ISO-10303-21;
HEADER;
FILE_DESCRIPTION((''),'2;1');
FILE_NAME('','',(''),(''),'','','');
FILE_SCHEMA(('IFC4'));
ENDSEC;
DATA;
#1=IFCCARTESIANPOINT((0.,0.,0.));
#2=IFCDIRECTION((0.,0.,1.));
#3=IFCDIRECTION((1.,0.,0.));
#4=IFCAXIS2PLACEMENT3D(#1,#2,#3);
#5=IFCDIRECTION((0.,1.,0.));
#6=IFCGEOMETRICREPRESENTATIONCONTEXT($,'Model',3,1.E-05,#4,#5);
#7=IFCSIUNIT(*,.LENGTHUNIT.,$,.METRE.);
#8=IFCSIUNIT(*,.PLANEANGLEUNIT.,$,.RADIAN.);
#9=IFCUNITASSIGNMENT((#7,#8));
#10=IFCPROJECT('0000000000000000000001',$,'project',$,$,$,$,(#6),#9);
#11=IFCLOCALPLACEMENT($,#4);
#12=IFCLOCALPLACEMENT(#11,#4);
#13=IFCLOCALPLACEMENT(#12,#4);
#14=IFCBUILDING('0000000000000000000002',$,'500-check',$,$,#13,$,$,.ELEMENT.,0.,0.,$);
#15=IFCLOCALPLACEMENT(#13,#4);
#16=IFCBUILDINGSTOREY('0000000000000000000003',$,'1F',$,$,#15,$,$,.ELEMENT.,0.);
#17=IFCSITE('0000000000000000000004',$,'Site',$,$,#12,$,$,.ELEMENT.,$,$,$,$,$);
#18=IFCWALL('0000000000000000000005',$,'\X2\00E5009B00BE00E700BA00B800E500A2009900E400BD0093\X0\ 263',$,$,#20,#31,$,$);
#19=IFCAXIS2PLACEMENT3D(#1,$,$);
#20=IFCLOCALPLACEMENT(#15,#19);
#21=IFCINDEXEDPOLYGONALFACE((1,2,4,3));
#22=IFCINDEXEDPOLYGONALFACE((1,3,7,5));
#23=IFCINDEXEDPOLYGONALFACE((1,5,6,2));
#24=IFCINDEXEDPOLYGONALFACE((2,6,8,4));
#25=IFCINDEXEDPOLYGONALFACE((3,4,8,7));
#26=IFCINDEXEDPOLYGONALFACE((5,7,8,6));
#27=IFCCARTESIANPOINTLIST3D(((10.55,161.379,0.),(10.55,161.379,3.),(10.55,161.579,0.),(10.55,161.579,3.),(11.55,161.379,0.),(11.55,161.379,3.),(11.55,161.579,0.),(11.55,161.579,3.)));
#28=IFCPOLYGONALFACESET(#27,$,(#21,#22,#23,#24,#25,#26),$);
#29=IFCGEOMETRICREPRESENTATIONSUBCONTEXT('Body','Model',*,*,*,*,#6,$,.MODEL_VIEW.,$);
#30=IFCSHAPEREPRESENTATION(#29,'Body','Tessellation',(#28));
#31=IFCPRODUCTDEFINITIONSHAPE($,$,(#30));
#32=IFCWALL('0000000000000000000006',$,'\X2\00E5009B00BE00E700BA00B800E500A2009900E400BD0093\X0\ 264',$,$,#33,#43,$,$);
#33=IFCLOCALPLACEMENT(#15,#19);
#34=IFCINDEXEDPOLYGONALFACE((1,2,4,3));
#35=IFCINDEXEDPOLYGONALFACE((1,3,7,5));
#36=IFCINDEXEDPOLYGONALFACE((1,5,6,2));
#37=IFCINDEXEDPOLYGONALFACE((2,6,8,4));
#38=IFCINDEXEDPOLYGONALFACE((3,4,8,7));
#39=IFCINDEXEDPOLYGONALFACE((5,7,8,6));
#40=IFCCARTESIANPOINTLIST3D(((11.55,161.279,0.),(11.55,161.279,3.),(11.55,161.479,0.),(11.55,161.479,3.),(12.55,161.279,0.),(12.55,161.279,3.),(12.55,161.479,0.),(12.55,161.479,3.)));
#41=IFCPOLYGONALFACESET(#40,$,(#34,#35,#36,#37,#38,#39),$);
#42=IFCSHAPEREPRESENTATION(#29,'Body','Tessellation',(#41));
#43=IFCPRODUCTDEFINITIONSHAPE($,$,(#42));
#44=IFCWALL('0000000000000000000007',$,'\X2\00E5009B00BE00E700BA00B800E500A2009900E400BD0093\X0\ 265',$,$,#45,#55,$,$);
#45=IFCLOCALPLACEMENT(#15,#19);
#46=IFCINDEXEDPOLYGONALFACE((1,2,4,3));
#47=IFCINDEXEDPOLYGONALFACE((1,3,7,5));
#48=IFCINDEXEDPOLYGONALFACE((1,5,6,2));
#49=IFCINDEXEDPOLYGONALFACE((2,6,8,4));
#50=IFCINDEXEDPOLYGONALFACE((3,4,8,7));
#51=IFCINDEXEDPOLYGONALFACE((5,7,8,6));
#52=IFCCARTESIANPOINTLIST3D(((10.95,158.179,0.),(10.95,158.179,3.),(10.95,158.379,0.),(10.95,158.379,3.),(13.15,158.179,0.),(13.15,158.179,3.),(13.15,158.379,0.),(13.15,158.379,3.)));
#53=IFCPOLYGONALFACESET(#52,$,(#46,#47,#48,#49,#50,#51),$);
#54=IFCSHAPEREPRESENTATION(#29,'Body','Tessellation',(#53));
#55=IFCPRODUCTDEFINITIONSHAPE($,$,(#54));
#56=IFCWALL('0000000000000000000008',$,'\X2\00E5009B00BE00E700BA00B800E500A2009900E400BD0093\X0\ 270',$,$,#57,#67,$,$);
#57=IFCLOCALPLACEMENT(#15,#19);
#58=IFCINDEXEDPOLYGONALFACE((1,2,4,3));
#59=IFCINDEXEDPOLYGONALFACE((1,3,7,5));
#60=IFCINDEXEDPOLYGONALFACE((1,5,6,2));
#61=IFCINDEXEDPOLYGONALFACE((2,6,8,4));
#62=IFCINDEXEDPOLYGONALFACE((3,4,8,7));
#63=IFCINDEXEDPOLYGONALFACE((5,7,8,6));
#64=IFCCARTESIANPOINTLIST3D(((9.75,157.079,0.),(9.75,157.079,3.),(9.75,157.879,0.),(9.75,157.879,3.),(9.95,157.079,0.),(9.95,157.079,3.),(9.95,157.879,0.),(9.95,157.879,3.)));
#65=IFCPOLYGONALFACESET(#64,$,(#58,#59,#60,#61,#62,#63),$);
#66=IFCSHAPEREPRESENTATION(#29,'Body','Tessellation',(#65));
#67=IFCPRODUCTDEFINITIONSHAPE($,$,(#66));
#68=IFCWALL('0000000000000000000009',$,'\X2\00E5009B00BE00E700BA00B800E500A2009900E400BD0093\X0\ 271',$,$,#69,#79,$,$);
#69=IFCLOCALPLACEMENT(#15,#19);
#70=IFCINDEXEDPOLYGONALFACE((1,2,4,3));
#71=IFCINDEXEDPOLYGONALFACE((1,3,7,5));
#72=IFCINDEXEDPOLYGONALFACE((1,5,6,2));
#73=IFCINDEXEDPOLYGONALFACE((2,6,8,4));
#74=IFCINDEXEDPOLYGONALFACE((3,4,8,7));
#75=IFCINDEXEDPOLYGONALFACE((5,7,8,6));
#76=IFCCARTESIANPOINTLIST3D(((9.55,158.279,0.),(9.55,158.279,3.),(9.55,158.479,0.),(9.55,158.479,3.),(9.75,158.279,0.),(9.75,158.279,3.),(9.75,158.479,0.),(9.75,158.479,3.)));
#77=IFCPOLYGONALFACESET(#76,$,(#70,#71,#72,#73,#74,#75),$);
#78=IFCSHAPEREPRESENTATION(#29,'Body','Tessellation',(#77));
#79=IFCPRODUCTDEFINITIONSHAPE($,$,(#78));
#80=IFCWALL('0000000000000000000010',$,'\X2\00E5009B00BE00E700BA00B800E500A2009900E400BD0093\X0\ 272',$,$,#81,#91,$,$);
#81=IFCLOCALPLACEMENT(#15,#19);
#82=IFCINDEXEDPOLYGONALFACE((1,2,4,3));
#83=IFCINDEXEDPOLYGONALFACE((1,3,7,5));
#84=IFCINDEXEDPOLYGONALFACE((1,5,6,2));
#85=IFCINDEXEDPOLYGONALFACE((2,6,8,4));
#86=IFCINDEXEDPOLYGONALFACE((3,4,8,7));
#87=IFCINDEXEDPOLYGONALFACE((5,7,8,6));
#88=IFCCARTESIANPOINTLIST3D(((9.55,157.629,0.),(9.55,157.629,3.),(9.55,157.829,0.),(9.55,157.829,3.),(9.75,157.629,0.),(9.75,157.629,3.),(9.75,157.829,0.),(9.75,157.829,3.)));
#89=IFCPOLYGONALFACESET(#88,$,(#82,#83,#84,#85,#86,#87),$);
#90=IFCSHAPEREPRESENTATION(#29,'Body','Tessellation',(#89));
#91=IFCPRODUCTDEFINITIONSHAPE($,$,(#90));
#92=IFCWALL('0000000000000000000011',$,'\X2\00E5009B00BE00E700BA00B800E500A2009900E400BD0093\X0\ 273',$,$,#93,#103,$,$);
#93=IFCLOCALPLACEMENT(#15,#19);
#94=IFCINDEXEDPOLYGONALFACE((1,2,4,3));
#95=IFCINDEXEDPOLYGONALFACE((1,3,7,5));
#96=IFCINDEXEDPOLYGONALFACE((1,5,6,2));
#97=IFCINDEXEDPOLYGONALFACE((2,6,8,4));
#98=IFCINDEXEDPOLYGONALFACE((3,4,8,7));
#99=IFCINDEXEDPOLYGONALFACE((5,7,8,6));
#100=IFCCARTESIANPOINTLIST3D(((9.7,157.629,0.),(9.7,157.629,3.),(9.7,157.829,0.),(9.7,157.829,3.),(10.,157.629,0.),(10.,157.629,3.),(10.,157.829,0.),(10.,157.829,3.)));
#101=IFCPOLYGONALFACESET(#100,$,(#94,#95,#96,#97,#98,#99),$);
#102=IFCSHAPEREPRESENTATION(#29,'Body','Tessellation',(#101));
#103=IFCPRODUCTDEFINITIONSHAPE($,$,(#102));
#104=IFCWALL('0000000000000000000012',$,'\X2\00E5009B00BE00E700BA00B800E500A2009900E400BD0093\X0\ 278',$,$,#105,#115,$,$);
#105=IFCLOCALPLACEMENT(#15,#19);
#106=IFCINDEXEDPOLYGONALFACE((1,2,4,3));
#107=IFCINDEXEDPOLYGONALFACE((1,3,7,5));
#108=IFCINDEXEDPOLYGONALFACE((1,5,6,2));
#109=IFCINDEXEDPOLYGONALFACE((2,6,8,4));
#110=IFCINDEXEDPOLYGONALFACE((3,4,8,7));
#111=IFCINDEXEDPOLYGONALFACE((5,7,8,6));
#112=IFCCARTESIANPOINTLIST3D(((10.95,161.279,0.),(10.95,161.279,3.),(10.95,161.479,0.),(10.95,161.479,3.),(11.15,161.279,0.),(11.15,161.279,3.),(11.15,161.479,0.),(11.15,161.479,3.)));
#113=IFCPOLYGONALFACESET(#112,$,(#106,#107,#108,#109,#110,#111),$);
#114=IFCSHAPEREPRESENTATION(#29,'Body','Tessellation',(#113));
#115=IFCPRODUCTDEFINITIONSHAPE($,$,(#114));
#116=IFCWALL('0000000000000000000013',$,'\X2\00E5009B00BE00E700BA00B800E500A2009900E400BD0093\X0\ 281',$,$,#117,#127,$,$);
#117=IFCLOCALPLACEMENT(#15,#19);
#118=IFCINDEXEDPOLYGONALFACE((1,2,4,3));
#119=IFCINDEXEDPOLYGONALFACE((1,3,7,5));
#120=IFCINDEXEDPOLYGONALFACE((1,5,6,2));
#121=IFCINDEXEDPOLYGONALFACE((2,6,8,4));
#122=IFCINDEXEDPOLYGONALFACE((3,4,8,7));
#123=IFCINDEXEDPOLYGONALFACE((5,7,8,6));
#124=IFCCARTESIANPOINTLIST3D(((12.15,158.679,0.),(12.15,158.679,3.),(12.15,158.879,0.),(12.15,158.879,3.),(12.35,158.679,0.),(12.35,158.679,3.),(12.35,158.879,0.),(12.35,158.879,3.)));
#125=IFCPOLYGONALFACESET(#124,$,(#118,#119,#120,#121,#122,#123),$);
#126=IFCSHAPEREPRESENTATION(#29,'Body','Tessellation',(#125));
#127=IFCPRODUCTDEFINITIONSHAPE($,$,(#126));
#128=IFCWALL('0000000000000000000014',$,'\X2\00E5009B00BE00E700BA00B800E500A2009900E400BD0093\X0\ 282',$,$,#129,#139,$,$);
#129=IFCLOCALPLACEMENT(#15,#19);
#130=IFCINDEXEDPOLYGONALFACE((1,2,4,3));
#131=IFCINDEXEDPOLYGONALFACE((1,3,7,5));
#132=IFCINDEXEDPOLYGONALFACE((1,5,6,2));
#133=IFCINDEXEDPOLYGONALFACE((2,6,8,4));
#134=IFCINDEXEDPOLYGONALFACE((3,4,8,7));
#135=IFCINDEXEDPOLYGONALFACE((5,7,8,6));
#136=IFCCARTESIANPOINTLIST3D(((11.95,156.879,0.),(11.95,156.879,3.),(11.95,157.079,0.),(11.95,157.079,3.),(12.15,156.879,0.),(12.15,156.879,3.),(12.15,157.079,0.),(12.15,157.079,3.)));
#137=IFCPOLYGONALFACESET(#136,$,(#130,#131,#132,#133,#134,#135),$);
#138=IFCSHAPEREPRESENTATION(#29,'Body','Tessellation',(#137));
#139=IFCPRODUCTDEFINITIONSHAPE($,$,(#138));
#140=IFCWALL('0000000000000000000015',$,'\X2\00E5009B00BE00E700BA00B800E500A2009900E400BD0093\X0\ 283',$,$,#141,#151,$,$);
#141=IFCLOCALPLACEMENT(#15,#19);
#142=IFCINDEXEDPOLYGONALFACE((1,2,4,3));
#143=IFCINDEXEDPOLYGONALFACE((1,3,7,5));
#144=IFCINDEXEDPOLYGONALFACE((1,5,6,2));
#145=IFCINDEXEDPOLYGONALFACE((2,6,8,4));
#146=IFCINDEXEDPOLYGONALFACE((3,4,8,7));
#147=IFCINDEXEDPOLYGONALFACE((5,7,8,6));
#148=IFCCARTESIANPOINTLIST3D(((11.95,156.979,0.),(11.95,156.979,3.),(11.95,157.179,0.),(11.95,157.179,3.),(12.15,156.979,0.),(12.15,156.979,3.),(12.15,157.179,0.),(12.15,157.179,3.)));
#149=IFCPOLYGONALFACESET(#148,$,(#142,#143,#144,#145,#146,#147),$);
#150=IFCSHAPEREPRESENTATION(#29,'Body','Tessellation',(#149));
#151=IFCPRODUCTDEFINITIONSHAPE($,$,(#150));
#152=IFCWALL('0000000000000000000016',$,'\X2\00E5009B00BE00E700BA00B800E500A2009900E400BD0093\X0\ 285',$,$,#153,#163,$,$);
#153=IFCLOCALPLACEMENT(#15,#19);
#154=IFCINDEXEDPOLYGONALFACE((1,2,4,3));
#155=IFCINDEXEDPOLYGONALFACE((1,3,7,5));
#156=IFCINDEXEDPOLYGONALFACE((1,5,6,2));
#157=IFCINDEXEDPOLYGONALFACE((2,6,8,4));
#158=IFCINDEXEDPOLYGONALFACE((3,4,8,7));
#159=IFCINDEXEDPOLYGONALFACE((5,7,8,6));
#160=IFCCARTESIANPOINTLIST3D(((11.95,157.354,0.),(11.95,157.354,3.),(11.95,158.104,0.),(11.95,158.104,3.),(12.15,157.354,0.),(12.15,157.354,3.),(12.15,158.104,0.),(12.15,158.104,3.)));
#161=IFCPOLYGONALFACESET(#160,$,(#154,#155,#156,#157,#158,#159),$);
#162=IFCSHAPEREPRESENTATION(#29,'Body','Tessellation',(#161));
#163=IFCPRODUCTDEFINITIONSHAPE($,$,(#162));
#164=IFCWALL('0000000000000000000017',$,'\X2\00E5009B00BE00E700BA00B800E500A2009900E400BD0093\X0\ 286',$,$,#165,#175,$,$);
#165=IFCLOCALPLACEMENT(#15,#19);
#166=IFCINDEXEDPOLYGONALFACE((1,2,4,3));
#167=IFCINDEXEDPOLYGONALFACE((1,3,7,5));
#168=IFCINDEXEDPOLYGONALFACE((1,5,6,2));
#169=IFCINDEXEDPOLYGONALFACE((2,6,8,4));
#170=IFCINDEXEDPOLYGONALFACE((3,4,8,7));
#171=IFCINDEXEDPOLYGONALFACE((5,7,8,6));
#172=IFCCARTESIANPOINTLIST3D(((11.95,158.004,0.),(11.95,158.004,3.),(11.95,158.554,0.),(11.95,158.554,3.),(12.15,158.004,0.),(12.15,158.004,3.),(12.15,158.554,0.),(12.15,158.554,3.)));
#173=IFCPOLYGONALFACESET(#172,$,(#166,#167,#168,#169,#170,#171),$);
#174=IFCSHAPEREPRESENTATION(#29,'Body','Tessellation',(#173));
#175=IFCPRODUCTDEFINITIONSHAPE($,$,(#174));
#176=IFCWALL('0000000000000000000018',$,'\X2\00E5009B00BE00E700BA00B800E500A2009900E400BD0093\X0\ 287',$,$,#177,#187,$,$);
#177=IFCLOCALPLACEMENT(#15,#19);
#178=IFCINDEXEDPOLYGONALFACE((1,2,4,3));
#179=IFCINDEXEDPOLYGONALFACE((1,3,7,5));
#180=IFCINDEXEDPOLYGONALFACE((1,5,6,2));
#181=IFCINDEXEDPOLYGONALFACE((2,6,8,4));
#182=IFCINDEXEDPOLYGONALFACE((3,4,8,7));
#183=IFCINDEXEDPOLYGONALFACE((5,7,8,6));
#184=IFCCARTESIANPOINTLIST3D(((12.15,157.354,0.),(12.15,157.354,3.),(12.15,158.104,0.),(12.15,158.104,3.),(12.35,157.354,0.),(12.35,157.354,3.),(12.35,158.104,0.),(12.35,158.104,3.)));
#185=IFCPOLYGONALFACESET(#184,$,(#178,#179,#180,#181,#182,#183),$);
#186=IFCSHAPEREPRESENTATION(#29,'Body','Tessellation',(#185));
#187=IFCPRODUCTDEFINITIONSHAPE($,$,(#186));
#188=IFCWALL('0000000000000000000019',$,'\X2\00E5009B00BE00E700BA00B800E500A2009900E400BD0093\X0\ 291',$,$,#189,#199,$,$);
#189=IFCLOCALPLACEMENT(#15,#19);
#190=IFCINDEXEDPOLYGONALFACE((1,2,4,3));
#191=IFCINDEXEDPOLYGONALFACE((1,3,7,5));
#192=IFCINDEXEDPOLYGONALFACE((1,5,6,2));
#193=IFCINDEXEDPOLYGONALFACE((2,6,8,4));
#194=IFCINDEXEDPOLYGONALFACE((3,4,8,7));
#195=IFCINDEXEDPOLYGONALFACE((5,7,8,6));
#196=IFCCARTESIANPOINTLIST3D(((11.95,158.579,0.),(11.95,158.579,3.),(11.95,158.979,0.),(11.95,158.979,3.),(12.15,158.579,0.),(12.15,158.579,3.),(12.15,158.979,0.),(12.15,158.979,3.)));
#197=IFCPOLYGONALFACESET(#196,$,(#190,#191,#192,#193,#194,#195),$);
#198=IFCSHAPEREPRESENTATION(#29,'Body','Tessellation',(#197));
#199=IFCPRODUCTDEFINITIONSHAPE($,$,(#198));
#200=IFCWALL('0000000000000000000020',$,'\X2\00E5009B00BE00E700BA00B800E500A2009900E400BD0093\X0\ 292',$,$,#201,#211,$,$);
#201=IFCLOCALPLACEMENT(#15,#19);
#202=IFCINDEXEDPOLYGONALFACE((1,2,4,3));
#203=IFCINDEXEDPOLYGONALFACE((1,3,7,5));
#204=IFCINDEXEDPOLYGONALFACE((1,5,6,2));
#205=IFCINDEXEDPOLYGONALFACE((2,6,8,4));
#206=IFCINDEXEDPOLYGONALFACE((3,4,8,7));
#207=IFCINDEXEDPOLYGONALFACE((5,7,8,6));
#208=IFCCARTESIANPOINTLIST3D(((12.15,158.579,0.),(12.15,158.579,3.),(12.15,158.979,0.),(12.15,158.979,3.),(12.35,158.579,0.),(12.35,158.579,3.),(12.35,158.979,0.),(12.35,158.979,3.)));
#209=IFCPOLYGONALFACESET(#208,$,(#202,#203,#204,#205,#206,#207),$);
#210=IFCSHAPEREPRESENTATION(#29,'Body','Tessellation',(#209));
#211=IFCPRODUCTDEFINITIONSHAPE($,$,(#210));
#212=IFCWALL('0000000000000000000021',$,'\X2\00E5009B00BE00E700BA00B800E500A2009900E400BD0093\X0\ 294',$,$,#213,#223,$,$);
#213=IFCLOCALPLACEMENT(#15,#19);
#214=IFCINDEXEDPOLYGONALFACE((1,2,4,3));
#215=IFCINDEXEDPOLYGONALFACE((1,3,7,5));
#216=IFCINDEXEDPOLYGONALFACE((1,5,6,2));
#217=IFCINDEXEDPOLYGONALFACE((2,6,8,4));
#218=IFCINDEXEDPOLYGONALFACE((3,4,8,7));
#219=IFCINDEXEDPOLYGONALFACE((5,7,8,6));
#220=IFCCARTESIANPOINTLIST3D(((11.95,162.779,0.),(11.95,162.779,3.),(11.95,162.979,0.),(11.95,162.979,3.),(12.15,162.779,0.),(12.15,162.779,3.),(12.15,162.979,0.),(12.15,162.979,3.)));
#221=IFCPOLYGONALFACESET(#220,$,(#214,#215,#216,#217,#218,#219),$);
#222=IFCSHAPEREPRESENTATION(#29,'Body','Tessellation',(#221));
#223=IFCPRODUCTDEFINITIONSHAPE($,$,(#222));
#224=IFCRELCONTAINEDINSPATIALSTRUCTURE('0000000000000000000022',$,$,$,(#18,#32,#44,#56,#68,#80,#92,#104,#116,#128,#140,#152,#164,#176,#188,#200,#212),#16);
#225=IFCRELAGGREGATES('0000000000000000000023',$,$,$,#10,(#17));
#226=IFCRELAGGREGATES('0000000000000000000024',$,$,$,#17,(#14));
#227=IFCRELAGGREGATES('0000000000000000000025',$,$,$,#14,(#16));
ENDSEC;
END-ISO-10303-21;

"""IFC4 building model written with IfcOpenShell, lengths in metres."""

from ifc_helpers import new_model, si_unit, direction, frame, frame_2d, origin_with_axes, place, context, subcontext, project, spatial, rectangle, extrude, element, save


model = new_model("IFC4")

# Units and contexts
model_context = context("Model", 3, precision=1e-05, world=origin_with_axes(), true_north=direction((0.0, 1.0, 0.0)))
body_context = subcontext(model_context, "Body", "Model", "MODEL_VIEW")
ifc_project = project(units=[si_unit("LENGTHUNIT", "METRE"), si_unit("PLANEANGLEUNIT", "RADIAN")], contexts=[model_context])

# Site, building, storey
placement = place(None, origin_with_axes())
site_placement = place(placement, origin_with_axes())
site = spatial("IfcSite", under=ifc_project, at=site_placement, Name="Site", CompositionType="ELEMENT")
building_placement = place(site_placement, origin_with_axes())
building = spatial("IfcBuilding", under=site, at=building_placement, Name="500-check", CompositionType="ELEMENT", ElevationOfRefHeight=0.0, ElevationOfTerrain=0.0)
storey_placement = place(building_placement, origin_with_axes())
storey = spatial("IfcBuildingStorey", under=building, at=storey_placement, Name="1F", CompositionType="ELEMENT", Elevation=0.0)

# Walls
for number, where, z_axis, x_axis, name in (
    (1, (11.05, 161.479, 0.0), (0.0, 0.0, 1.0), (1.0, 0.0, 0.0), "å\u009b¾çº¸å¢\u0099ä½\u0093 263"),
    (2, (12.05, 161.379, 0.0), (0.0, 0.0, 1.0), (-1.0, 0.0, 0.0), "å\u009b¾çº¸å¢\u0099ä½\u0093 264"),
):
    element("IfcWall", number, at=place(storey_placement, frame(where, z_axis=z_axis, x_axis=x_axis)), inside=storey, Name=name, context=body_context, shape_type="SweptSolid", body=[
        extrude(rectangle(XDim=1.0, YDim=0.2, at=frame_2d((0.0, 0.0), x_axis=(1.0, 0.0, 0.0))), frame((0.0, 0.0, 0.0), z_axis=(0.0, 0.0, 1.0)), (0.0, 0.0, 1.0), 3.0),
    ])
wall_1_placement = place(storey_placement, frame((12.05, 158.279, 0.0), z_axis=(0.0, 0.0, 1.0), x_axis=(-1.0, 0.0, 0.0)))
element("IfcWall", 3, at=wall_1_placement, inside=storey, Name="å\u009b¾çº¸å¢\u0099ä½\u0093 265", context=body_context, shape_type="SweptSolid", body=[
    extrude(rectangle(XDim=2.2, YDim=0.2, at=frame_2d((0.0, 0.0), x_axis=(1.0, 0.0, 0.0))), frame((0.0, 0.0, 0.0), z_axis=(0.0, 0.0, 1.0)), (0.0, 0.0, 1.0), 3.0),
])
wall_2_placement = place(storey_placement, frame((9.85, 157.479, 0.0), z_axis=(0.0, 0.0, 1.0), x_axis=(0.0, 1.0, 0.0)))
element("IfcWall", 4, at=wall_2_placement, inside=storey, Name="å\u009b¾çº¸å¢\u0099ä½\u0093 270", context=body_context, shape_type="SweptSolid", body=[
    extrude(rectangle(XDim=0.8, YDim=0.2, at=frame_2d((0.0, 0.0), x_axis=(1.0, 0.0, 0.0))), frame((0.0, 0.0, 0.0), z_axis=(0.0, 0.0, 1.0)), (0.0, 0.0, 1.0), 3.0),
])
for number, where, z_axis, x_axis, name in (
    (5, (9.65, 158.379, 0.0), (0.0, 0.0, 1.0), (1.0, 0.0, 0.0), "å\u009b¾çº¸å¢\u0099ä½\u0093 271"),
    (6, (9.65, 157.729, 0.0), (0.0, 0.0, 1.0), (1.0, 0.0, 0.0), "å\u009b¾çº¸å¢\u0099ä½\u0093 272"),
):
    element("IfcWall", number, at=place(storey_placement, frame(where, z_axis=z_axis, x_axis=x_axis)), inside=storey, Name=name, context=body_context, shape_type="SweptSolid", body=[
        extrude(rectangle(XDim=0.2, YDim=0.2, at=frame_2d((0.0, 0.0), x_axis=(1.0, 0.0, 0.0))), frame((0.0, 0.0, 0.0), z_axis=(0.0, 0.0, 1.0)), (0.0, 0.0, 1.0), 3.0),
    ])
wall_3_placement = place(storey_placement, frame((9.85, 157.729, 0.0), z_axis=(0.0, 0.0, 1.0), x_axis=(-1.0, 0.0, 0.0)))
element("IfcWall", 7, at=wall_3_placement, inside=storey, Name="å\u009b¾çº¸å¢\u0099ä½\u0093 273", context=body_context, shape_type="SweptSolid", body=[
    extrude(rectangle(XDim=0.3, YDim=0.2, at=frame_2d((0.0, 0.0), x_axis=(1.0, 0.0, 0.0))), frame((0.0, 0.0, 0.0), z_axis=(0.0, 0.0, 1.0)), (0.0, 0.0, 1.0), 3.0),
])
for number, where, z_axis, x_axis, name in (
    (8, (11.05, 161.379, 0.0), (0.0, 0.0, 1.0), (0.0, 1.0, 0.0), "å\u009b¾çº¸å¢\u0099ä½\u0093 278"),
    (9, (12.25, 158.779, 0.0), (0.0, 0.0, 1.0), (-1.0, 0.0, 0.0), "å\u009b¾çº¸å¢\u0099ä½\u0093 281"),
    (10, (12.05, 156.979, 0.0), (0.0, 0.0, 1.0), (1.0, 0.0, 0.0), "å\u009b¾çº¸å¢\u0099ä½\u0093 282"),
    (11, (12.05, 157.079, 0.0), (0.0, 0.0, 1.0), (1.0, 0.0, 0.0), "å\u009b¾çº¸å¢\u0099ä½\u0093 283"),
):
    element("IfcWall", number, at=place(storey_placement, frame(where, z_axis=z_axis, x_axis=x_axis)), inside=storey, Name=name, context=body_context, shape_type="SweptSolid", body=[
        extrude(rectangle(XDim=0.2, YDim=0.2, at=frame_2d((0.0, 0.0), x_axis=(1.0, 0.0, 0.0))), frame((0.0, 0.0, 0.0), z_axis=(0.0, 0.0, 1.0)), (0.0, 0.0, 1.0), 3.0),
    ])
wall_4_placement = place(storey_placement, frame((12.05, 157.729, 0.0), z_axis=(0.0, 0.0, 1.0), x_axis=(0.0, -1.0, 0.0)))
element("IfcWall", 12, at=wall_4_placement, inside=storey, Name="å\u009b¾çº¸å¢\u0099ä½\u0093 285", context=body_context, shape_type="SweptSolid", body=[
    extrude(rectangle(XDim=0.75, YDim=0.2, at=frame_2d((0.0, 0.0), x_axis=(1.0, 0.0, 0.0))), frame((0.0, 0.0, 0.0), z_axis=(0.0, 0.0, 1.0)), (0.0, 0.0, 1.0), 3.0),
])
wall_5_placement = place(storey_placement, frame((12.05, 158.279, 0.0), z_axis=(0.0, 0.0, 1.0), x_axis=(0.0, -1.0, 0.0)))
element("IfcWall", 13, at=wall_5_placement, inside=storey, Name="å\u009b¾çº¸å¢\u0099ä½\u0093 286", context=body_context, shape_type="SweptSolid", body=[
    extrude(rectangle(XDim=0.55, YDim=0.2, at=frame_2d((0.0, 0.0), x_axis=(1.0, 0.0, 0.0))), frame((0.0, 0.0, 0.0), z_axis=(0.0, 0.0, 1.0)), (0.0, 0.0, 1.0), 3.0),
])
wall_6_placement = place(storey_placement, frame((12.25, 157.729, 0.0), z_axis=(0.0, 0.0, 1.0), x_axis=(0.0, -1.0, 0.0)))
element("IfcWall", 14, at=wall_6_placement, inside=storey, Name="å\u009b¾çº¸å¢\u0099ä½\u0093 287", context=body_context, shape_type="SweptSolid", body=[
    extrude(rectangle(XDim=0.75, YDim=0.2, at=frame_2d((0.0, 0.0), x_axis=(1.0, 0.0, 0.0))), frame((0.0, 0.0, 0.0), z_axis=(0.0, 0.0, 1.0)), (0.0, 0.0, 1.0), 3.0),
])
for number, where, z_axis, x_axis, name in (
    (15, (12.05, 158.779, 0.0), (0.0, 0.0, 1.0), (0.0, -1.0, 0.0), "å\u009b¾çº¸å¢\u0099ä½\u0093 291"),
    (16, (12.25, 158.779, 0.0), (0.0, 0.0, 1.0), (0.0, -1.0, 0.0), "å\u009b¾çº¸å¢\u0099ä½\u0093 292"),
):
    element("IfcWall", number, at=place(storey_placement, frame(where, z_axis=z_axis, x_axis=x_axis)), inside=storey, Name=name, context=body_context, shape_type="SweptSolid", body=[
        extrude(rectangle(XDim=0.4, YDim=0.2, at=frame_2d((0.0, 0.0), x_axis=(1.0, 0.0, 0.0))), frame((0.0, 0.0, 0.0), z_axis=(0.0, 0.0, 1.0)), (0.0, 0.0, 1.0), 3.0),
    ])
for number, where, z_axis, x_axis, name in (
    (17, (12.05, 162.879, 0.0), (0.0, 0.0, 1.0), (1.0, 0.0, 0.0), "å\u009b¾çº¸å¢\u0099ä½\u0093 294"),
):
    element("IfcWall", number, at=place(storey_placement, frame(where, z_axis=z_axis, x_axis=x_axis)), inside=storey, Name=name, context=body_context, shape_type="SweptSolid", body=[
        extrude(rectangle(XDim=0.2, YDim=0.2, at=frame_2d((0.0, 0.0), x_axis=(1.0, 0.0, 0.0))), frame((0.0, 0.0, 0.0), z_axis=(0.0, 0.0, 1.0)), (0.0, 0.0, 1.0), 3.0),
    ])

save(model, "model.ifc")
